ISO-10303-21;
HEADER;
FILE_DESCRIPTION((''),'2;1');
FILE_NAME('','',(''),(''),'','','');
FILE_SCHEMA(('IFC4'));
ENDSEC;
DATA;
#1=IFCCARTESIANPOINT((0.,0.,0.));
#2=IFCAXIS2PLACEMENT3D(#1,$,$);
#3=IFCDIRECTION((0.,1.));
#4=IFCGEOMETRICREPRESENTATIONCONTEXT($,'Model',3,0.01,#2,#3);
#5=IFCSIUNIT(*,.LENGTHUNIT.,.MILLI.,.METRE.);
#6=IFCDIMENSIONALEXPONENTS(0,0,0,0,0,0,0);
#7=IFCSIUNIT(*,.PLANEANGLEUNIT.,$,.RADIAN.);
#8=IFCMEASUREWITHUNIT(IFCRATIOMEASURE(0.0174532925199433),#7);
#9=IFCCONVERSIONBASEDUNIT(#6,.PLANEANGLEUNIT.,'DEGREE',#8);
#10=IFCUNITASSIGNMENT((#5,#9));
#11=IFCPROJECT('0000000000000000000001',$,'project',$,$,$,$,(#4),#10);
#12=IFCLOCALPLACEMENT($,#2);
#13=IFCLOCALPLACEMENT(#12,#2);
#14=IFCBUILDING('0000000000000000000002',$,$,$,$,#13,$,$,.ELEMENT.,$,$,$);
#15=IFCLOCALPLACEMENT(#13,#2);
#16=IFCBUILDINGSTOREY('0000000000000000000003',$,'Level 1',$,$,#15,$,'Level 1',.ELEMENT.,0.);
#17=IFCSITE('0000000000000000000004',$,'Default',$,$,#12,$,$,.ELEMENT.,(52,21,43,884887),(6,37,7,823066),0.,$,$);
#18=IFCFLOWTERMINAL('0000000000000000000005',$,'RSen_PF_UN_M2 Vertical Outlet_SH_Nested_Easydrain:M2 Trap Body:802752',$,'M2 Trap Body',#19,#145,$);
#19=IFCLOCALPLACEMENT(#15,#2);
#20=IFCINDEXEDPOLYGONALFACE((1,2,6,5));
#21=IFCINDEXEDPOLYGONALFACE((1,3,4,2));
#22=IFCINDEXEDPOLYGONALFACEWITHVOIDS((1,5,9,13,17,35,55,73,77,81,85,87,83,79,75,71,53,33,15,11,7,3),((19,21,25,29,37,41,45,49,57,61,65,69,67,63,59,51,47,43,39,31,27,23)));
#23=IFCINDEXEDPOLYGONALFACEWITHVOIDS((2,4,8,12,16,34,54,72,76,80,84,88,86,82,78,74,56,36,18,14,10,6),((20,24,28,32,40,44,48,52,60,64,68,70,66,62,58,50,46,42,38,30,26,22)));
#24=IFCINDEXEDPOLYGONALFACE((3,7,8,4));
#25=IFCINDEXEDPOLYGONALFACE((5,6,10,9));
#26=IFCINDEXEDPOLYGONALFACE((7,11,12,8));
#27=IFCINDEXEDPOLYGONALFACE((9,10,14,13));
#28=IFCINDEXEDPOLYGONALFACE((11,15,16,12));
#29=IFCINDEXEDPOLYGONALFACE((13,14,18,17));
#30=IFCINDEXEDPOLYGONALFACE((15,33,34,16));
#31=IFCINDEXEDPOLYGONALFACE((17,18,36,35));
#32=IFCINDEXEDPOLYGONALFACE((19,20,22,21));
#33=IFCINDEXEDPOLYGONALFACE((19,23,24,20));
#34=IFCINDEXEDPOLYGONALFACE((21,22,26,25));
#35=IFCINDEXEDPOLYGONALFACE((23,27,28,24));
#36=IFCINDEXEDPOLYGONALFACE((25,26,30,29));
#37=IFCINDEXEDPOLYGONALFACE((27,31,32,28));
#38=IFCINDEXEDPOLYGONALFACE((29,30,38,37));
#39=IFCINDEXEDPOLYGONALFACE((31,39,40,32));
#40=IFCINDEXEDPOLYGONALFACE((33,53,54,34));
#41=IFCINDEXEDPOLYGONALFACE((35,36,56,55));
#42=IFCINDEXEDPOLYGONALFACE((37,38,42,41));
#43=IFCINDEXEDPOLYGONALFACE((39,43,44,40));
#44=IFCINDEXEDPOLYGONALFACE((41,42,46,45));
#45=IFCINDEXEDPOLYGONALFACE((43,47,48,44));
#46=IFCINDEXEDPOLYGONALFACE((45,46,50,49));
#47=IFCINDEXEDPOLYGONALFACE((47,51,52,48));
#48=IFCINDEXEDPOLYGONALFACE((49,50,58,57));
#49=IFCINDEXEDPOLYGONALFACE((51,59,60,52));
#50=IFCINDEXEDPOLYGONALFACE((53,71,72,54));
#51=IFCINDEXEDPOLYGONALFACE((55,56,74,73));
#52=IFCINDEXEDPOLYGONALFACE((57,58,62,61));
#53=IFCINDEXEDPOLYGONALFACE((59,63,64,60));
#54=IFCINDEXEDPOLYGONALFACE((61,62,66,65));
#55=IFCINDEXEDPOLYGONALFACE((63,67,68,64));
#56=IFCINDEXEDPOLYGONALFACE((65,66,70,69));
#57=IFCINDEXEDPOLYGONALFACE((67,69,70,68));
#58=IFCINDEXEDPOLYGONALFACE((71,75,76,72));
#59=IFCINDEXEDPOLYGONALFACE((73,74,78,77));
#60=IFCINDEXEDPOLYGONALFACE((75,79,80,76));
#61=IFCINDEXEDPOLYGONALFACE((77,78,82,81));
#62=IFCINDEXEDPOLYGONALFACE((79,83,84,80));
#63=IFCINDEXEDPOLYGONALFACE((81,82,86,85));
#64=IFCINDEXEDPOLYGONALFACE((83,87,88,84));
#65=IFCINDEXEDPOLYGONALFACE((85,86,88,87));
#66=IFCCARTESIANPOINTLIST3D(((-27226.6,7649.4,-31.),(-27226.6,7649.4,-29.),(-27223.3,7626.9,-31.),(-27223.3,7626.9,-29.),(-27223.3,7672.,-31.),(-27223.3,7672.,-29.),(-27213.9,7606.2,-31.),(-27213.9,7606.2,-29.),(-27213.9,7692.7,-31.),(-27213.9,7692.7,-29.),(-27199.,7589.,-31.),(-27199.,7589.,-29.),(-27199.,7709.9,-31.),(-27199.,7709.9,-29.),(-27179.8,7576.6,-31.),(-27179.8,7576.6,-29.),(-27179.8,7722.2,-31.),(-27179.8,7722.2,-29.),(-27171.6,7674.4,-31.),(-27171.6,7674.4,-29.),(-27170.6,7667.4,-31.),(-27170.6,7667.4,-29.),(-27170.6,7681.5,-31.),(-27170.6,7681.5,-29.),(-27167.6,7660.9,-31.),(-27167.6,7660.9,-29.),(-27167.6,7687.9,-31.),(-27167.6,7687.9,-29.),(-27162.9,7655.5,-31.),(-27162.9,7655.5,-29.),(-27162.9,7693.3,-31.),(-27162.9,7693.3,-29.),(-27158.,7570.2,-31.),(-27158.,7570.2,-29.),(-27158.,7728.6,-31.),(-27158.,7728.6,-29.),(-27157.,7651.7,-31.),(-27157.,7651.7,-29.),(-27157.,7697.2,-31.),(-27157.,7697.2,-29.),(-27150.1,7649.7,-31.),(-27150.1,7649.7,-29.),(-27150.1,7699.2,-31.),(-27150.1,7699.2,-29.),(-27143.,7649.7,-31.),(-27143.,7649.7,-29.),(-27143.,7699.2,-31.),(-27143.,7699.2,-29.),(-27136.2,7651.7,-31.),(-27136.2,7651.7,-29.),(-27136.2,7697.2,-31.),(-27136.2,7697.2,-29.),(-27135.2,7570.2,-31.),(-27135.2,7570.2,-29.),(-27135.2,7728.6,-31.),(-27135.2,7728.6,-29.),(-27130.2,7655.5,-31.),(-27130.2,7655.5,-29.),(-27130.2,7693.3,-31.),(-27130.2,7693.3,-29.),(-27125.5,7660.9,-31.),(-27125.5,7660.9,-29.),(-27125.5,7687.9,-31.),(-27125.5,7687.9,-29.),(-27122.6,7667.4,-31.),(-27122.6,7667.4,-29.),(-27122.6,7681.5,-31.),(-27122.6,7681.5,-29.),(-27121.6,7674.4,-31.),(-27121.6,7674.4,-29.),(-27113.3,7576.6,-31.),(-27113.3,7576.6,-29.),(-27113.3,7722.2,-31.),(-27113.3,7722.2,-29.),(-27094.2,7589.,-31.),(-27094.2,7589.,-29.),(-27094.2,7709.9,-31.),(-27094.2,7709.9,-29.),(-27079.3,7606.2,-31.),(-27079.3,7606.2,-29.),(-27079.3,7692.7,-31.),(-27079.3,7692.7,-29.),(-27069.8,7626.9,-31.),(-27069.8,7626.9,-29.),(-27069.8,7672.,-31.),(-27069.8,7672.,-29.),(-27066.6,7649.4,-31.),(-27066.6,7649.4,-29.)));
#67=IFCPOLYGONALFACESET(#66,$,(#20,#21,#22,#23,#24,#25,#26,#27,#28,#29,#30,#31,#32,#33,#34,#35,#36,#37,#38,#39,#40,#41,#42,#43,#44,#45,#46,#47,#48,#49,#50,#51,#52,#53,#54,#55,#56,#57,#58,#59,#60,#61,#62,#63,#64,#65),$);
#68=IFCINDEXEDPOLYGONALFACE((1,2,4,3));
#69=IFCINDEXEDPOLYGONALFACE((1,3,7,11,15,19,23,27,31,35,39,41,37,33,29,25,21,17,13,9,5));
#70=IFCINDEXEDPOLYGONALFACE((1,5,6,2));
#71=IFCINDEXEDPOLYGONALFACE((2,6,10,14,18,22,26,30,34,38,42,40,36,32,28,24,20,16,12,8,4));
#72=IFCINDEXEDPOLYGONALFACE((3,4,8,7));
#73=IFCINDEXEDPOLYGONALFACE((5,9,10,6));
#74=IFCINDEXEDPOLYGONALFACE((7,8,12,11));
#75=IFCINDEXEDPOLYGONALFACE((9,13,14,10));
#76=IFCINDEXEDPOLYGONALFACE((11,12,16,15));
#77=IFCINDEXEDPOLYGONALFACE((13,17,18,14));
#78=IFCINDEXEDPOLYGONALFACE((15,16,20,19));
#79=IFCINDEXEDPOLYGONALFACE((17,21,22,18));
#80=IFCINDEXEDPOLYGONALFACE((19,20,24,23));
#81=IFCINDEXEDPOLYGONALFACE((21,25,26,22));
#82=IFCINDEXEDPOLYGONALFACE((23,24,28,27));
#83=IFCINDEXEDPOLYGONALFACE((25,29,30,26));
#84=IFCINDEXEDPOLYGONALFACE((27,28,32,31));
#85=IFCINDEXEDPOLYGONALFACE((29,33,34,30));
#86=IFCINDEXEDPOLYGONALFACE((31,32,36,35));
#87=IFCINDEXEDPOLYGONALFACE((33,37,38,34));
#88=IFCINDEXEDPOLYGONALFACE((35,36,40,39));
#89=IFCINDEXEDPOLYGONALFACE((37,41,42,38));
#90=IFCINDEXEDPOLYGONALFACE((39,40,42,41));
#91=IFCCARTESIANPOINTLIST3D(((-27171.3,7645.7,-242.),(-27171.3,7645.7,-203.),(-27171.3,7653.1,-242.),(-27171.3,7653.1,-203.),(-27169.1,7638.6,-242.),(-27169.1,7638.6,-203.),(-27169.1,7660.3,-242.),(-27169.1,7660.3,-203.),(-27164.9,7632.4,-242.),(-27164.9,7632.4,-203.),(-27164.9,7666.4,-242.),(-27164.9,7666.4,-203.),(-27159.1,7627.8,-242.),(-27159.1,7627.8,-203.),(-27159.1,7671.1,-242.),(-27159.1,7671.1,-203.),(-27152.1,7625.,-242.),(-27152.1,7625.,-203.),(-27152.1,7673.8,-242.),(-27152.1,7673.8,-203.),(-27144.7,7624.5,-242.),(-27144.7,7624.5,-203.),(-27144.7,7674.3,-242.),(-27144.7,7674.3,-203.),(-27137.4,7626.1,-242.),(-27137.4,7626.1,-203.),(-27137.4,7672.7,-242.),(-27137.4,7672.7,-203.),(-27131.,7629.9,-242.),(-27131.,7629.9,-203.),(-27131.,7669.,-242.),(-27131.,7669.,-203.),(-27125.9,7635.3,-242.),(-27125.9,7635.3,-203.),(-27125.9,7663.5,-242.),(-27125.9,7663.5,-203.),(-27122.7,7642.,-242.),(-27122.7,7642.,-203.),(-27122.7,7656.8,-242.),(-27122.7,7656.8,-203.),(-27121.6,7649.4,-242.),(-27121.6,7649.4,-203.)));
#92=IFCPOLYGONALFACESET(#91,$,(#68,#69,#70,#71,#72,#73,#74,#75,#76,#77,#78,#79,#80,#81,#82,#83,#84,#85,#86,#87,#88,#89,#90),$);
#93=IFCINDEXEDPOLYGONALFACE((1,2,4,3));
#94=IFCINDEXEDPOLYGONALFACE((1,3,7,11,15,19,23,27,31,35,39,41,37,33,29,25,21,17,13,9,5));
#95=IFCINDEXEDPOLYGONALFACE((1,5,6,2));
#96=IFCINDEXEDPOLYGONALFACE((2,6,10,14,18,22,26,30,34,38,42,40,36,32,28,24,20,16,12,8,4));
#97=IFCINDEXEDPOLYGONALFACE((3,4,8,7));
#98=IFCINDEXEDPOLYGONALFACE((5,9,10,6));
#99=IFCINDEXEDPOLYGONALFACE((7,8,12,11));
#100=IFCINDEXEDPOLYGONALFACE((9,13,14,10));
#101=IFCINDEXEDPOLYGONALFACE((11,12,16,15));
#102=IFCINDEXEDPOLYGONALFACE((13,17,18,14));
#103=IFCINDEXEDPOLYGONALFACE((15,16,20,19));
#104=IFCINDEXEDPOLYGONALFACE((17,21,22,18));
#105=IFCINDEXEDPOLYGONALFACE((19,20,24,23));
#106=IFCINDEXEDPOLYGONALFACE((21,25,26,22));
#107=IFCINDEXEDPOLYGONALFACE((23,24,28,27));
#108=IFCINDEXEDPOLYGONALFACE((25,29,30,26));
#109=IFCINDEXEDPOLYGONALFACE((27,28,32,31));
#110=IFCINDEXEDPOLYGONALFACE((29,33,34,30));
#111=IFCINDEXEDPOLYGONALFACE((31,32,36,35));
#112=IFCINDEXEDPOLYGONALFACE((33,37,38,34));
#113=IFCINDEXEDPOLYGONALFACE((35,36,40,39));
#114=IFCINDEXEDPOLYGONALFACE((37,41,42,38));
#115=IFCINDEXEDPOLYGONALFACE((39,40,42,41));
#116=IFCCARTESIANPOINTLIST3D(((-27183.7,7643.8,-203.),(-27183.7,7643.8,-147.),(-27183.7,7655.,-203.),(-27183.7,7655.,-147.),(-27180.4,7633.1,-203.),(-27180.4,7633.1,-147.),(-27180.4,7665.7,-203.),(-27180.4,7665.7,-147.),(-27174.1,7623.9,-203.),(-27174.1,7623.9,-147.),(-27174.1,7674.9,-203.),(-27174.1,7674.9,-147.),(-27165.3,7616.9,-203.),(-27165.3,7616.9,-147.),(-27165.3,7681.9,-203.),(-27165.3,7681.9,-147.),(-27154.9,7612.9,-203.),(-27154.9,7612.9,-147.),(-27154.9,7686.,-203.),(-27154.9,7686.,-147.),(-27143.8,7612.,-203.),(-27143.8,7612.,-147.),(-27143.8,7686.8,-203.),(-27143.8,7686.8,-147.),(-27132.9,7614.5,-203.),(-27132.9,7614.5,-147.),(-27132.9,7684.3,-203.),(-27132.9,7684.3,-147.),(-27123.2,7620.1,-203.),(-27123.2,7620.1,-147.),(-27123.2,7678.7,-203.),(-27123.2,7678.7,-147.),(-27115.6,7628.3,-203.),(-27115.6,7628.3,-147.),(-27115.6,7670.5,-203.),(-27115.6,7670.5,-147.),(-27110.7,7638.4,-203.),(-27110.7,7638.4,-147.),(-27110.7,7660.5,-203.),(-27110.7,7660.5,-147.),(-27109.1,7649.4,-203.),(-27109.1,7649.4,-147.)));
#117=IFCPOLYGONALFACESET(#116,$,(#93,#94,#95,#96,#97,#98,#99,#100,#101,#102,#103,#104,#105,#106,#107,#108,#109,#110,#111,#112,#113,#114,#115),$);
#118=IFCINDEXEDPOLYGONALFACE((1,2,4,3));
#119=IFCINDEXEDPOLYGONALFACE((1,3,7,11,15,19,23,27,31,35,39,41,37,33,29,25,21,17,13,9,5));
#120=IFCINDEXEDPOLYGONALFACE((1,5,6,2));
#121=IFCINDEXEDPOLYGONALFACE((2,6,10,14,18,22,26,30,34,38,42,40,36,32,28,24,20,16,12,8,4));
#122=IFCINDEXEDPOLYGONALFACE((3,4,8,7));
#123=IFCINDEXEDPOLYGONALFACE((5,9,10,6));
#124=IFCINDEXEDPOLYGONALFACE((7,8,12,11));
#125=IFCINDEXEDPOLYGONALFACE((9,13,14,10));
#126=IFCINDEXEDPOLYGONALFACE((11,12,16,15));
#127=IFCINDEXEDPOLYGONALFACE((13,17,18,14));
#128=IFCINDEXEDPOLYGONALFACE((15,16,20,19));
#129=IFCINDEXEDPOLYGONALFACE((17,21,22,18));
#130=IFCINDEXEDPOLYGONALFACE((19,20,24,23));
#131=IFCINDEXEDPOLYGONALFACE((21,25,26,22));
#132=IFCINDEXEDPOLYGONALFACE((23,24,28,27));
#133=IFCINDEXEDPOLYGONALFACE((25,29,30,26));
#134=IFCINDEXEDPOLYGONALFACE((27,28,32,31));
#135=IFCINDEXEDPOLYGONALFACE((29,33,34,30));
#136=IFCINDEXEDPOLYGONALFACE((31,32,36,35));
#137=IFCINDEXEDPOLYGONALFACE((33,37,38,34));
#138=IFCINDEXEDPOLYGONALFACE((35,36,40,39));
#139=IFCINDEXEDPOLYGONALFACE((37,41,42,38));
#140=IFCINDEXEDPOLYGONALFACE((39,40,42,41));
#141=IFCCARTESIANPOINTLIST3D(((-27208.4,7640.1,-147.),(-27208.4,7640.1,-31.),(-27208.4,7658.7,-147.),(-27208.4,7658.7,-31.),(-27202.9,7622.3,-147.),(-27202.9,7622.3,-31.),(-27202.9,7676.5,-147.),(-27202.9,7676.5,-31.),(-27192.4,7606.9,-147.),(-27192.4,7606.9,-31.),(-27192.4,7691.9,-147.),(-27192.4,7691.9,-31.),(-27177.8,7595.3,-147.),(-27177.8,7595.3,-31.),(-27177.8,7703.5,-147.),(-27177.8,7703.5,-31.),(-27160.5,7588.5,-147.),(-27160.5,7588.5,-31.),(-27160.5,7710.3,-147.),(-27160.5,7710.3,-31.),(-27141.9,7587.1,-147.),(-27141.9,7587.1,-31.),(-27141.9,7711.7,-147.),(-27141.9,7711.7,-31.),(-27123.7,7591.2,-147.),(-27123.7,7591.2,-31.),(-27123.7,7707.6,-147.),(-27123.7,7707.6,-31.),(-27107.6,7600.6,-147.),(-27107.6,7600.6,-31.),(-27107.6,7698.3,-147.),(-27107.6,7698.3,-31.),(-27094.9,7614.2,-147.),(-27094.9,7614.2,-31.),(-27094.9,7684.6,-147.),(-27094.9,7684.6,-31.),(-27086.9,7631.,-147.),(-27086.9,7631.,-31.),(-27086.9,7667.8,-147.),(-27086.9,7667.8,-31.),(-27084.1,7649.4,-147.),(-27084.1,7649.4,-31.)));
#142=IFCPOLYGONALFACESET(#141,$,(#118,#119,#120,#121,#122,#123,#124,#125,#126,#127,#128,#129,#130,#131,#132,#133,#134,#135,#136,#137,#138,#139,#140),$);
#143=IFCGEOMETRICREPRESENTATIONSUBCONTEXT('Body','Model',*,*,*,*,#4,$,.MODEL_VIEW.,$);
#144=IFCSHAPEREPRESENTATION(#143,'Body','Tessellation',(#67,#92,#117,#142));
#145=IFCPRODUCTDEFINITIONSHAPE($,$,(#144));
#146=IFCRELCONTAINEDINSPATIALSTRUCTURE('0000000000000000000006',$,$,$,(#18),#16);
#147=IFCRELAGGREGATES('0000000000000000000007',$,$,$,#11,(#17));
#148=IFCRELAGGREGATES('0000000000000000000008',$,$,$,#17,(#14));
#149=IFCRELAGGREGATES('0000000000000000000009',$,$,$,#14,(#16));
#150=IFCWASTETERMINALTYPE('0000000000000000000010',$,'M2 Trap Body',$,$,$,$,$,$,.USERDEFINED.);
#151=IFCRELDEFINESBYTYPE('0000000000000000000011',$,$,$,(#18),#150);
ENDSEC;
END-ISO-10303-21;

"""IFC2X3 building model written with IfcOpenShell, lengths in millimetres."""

from ifc_helpers import new_model, entity, si_unit, converted_unit, direction, frame, frame_2d, origin, origin_2d_with_axis, place, context, subcontext, project, spatial, circle_curve, parameter, trimmed, segment, composite_curve, circle, outline, extrude, source, transform, mapped, type_object, type_shapes, element, save


model = new_model("IFC2X3")

# Units and contexts
model_context = context("Model", 3, precision=0.01, world=origin(), true_north=direction((0.0, 1.0)))
body_context = subcontext(model_context, "Body", "Model", "MODEL_VIEW")
ifc_project = project(units=[si_unit("LENGTHUNIT", "METRE", prefix="MILLI"), converted_unit("PLANEANGLEUNIT", "DEGREE", entity("IfcRatioMeasure", 0.0174532925199433), si_unit("PLANEANGLEUNIT", "RADIAN"), dimensions=[0, 0, 0, 0, 0, 0, 0])], contexts=[model_context])

# Site, building, storey
site_placement = place(None, origin())
site = spatial("IfcSite", under=ifc_project, at=site_placement, Name="Default", CompositionType="ELEMENT", RefLatitude=(52, 21, 43, 884887), RefLongitude=(6, 37, 7, 823066), RefElevation=0.0)
building_placement = place(site_placement, origin())
building = spatial("IfcBuilding", under=site, at=building_placement, CompositionType="ELEMENT")
storey_placement = place(building_placement, origin())
storey = spatial("IfcBuildingStorey", under=building, at=storey_placement, Name="Level 1", LongName="Level 1", CompositionType="ELEMENT", Elevation=0.0)

# Flow terminal
waste_terminal_type_1 = type_object("IfcWasteTerminalType", Name="M2 Trap Body", PredefinedType="USERDEFINED")
shared_shape_1 = source(origin(), body_context, "Body", "SweptSolid", [
    extrude(outline(composite_curve([segment(trimmed(circle_curve(origin_2d_with_axis(), 80.0), [parameter(0.0)], [parameter(180.0)], True, "PARAMETER"), True, "CONTINUOUS"), segment(trimmed(circle_curve(origin_2d_with_axis(), 80.0), [parameter(180.0)], [parameter(360.0)], True, "PARAMETER"), True, "CONTINUOUS")], self_intersect=False), holes=[composite_curve([segment(trimmed(circle_curve(frame_2d((0.0, 25.0), x_axis=(1.0, 0.0)), 25.0), [parameter(180.0)], [parameter(360.0)], True, "PARAMETER"), False, "CONTINUOUS"), segment(trimmed(circle_curve(frame_2d((0.0, 25.0), x_axis=(1.0, 0.0)), 25.0), [parameter(0.0)], [parameter(180.0)], True, "PARAMETER"), False, "CONTINUOUS")], self_intersect=False)]), frame((0.0, -25.0, -2.0)), (0.0, 0.0, 1.0), 2.0),
    extrude(circle(Radius=25.0, at=frame_2d((0.0, 0.0), x_axis=(1.0, 0.0))), frame((0.0, -25.0, -213.0)), (0.0, 0.0, 1.0), 39.0),
    extrude(circle(Radius=37.5, at=frame_2d((0.0, 0.0), x_axis=(1.0, 0.0))), frame((0.0, -25.0, -174.0)), (0.0, 0.0, 1.0), 56.0),
    extrude(circle(Radius=62.5, at=frame_2d((0.0, 0.0), x_axis=(1.0, 0.0))), frame((0.0, -25.0, -118.0)), (0.0, 0.0, 1.0), 116.0),
])
type_shapes(waste_terminal_type_1, [shared_shape_1])
for number, where, name in (
    (1, (-27146.6, 7674.4, -29.0), "RSen_PF_UN_M2 Vertical Outlet_SH_Nested_Easydrain:M2 Trap Body:802752"),
):
    element("IfcFlowTerminal", number, at=place(storey_placement, frame(where)), inside=storey, type_object=waste_terminal_type_1, Name=name, ObjectType="M2 Trap Body", context=body_context, shape_type="MappedRepresentation", body=[
        mapped(shared_shape_1, transform((0.0, 0.0, 0.0), scale=1.0)),
    ])

save(model, "model.ifc")
